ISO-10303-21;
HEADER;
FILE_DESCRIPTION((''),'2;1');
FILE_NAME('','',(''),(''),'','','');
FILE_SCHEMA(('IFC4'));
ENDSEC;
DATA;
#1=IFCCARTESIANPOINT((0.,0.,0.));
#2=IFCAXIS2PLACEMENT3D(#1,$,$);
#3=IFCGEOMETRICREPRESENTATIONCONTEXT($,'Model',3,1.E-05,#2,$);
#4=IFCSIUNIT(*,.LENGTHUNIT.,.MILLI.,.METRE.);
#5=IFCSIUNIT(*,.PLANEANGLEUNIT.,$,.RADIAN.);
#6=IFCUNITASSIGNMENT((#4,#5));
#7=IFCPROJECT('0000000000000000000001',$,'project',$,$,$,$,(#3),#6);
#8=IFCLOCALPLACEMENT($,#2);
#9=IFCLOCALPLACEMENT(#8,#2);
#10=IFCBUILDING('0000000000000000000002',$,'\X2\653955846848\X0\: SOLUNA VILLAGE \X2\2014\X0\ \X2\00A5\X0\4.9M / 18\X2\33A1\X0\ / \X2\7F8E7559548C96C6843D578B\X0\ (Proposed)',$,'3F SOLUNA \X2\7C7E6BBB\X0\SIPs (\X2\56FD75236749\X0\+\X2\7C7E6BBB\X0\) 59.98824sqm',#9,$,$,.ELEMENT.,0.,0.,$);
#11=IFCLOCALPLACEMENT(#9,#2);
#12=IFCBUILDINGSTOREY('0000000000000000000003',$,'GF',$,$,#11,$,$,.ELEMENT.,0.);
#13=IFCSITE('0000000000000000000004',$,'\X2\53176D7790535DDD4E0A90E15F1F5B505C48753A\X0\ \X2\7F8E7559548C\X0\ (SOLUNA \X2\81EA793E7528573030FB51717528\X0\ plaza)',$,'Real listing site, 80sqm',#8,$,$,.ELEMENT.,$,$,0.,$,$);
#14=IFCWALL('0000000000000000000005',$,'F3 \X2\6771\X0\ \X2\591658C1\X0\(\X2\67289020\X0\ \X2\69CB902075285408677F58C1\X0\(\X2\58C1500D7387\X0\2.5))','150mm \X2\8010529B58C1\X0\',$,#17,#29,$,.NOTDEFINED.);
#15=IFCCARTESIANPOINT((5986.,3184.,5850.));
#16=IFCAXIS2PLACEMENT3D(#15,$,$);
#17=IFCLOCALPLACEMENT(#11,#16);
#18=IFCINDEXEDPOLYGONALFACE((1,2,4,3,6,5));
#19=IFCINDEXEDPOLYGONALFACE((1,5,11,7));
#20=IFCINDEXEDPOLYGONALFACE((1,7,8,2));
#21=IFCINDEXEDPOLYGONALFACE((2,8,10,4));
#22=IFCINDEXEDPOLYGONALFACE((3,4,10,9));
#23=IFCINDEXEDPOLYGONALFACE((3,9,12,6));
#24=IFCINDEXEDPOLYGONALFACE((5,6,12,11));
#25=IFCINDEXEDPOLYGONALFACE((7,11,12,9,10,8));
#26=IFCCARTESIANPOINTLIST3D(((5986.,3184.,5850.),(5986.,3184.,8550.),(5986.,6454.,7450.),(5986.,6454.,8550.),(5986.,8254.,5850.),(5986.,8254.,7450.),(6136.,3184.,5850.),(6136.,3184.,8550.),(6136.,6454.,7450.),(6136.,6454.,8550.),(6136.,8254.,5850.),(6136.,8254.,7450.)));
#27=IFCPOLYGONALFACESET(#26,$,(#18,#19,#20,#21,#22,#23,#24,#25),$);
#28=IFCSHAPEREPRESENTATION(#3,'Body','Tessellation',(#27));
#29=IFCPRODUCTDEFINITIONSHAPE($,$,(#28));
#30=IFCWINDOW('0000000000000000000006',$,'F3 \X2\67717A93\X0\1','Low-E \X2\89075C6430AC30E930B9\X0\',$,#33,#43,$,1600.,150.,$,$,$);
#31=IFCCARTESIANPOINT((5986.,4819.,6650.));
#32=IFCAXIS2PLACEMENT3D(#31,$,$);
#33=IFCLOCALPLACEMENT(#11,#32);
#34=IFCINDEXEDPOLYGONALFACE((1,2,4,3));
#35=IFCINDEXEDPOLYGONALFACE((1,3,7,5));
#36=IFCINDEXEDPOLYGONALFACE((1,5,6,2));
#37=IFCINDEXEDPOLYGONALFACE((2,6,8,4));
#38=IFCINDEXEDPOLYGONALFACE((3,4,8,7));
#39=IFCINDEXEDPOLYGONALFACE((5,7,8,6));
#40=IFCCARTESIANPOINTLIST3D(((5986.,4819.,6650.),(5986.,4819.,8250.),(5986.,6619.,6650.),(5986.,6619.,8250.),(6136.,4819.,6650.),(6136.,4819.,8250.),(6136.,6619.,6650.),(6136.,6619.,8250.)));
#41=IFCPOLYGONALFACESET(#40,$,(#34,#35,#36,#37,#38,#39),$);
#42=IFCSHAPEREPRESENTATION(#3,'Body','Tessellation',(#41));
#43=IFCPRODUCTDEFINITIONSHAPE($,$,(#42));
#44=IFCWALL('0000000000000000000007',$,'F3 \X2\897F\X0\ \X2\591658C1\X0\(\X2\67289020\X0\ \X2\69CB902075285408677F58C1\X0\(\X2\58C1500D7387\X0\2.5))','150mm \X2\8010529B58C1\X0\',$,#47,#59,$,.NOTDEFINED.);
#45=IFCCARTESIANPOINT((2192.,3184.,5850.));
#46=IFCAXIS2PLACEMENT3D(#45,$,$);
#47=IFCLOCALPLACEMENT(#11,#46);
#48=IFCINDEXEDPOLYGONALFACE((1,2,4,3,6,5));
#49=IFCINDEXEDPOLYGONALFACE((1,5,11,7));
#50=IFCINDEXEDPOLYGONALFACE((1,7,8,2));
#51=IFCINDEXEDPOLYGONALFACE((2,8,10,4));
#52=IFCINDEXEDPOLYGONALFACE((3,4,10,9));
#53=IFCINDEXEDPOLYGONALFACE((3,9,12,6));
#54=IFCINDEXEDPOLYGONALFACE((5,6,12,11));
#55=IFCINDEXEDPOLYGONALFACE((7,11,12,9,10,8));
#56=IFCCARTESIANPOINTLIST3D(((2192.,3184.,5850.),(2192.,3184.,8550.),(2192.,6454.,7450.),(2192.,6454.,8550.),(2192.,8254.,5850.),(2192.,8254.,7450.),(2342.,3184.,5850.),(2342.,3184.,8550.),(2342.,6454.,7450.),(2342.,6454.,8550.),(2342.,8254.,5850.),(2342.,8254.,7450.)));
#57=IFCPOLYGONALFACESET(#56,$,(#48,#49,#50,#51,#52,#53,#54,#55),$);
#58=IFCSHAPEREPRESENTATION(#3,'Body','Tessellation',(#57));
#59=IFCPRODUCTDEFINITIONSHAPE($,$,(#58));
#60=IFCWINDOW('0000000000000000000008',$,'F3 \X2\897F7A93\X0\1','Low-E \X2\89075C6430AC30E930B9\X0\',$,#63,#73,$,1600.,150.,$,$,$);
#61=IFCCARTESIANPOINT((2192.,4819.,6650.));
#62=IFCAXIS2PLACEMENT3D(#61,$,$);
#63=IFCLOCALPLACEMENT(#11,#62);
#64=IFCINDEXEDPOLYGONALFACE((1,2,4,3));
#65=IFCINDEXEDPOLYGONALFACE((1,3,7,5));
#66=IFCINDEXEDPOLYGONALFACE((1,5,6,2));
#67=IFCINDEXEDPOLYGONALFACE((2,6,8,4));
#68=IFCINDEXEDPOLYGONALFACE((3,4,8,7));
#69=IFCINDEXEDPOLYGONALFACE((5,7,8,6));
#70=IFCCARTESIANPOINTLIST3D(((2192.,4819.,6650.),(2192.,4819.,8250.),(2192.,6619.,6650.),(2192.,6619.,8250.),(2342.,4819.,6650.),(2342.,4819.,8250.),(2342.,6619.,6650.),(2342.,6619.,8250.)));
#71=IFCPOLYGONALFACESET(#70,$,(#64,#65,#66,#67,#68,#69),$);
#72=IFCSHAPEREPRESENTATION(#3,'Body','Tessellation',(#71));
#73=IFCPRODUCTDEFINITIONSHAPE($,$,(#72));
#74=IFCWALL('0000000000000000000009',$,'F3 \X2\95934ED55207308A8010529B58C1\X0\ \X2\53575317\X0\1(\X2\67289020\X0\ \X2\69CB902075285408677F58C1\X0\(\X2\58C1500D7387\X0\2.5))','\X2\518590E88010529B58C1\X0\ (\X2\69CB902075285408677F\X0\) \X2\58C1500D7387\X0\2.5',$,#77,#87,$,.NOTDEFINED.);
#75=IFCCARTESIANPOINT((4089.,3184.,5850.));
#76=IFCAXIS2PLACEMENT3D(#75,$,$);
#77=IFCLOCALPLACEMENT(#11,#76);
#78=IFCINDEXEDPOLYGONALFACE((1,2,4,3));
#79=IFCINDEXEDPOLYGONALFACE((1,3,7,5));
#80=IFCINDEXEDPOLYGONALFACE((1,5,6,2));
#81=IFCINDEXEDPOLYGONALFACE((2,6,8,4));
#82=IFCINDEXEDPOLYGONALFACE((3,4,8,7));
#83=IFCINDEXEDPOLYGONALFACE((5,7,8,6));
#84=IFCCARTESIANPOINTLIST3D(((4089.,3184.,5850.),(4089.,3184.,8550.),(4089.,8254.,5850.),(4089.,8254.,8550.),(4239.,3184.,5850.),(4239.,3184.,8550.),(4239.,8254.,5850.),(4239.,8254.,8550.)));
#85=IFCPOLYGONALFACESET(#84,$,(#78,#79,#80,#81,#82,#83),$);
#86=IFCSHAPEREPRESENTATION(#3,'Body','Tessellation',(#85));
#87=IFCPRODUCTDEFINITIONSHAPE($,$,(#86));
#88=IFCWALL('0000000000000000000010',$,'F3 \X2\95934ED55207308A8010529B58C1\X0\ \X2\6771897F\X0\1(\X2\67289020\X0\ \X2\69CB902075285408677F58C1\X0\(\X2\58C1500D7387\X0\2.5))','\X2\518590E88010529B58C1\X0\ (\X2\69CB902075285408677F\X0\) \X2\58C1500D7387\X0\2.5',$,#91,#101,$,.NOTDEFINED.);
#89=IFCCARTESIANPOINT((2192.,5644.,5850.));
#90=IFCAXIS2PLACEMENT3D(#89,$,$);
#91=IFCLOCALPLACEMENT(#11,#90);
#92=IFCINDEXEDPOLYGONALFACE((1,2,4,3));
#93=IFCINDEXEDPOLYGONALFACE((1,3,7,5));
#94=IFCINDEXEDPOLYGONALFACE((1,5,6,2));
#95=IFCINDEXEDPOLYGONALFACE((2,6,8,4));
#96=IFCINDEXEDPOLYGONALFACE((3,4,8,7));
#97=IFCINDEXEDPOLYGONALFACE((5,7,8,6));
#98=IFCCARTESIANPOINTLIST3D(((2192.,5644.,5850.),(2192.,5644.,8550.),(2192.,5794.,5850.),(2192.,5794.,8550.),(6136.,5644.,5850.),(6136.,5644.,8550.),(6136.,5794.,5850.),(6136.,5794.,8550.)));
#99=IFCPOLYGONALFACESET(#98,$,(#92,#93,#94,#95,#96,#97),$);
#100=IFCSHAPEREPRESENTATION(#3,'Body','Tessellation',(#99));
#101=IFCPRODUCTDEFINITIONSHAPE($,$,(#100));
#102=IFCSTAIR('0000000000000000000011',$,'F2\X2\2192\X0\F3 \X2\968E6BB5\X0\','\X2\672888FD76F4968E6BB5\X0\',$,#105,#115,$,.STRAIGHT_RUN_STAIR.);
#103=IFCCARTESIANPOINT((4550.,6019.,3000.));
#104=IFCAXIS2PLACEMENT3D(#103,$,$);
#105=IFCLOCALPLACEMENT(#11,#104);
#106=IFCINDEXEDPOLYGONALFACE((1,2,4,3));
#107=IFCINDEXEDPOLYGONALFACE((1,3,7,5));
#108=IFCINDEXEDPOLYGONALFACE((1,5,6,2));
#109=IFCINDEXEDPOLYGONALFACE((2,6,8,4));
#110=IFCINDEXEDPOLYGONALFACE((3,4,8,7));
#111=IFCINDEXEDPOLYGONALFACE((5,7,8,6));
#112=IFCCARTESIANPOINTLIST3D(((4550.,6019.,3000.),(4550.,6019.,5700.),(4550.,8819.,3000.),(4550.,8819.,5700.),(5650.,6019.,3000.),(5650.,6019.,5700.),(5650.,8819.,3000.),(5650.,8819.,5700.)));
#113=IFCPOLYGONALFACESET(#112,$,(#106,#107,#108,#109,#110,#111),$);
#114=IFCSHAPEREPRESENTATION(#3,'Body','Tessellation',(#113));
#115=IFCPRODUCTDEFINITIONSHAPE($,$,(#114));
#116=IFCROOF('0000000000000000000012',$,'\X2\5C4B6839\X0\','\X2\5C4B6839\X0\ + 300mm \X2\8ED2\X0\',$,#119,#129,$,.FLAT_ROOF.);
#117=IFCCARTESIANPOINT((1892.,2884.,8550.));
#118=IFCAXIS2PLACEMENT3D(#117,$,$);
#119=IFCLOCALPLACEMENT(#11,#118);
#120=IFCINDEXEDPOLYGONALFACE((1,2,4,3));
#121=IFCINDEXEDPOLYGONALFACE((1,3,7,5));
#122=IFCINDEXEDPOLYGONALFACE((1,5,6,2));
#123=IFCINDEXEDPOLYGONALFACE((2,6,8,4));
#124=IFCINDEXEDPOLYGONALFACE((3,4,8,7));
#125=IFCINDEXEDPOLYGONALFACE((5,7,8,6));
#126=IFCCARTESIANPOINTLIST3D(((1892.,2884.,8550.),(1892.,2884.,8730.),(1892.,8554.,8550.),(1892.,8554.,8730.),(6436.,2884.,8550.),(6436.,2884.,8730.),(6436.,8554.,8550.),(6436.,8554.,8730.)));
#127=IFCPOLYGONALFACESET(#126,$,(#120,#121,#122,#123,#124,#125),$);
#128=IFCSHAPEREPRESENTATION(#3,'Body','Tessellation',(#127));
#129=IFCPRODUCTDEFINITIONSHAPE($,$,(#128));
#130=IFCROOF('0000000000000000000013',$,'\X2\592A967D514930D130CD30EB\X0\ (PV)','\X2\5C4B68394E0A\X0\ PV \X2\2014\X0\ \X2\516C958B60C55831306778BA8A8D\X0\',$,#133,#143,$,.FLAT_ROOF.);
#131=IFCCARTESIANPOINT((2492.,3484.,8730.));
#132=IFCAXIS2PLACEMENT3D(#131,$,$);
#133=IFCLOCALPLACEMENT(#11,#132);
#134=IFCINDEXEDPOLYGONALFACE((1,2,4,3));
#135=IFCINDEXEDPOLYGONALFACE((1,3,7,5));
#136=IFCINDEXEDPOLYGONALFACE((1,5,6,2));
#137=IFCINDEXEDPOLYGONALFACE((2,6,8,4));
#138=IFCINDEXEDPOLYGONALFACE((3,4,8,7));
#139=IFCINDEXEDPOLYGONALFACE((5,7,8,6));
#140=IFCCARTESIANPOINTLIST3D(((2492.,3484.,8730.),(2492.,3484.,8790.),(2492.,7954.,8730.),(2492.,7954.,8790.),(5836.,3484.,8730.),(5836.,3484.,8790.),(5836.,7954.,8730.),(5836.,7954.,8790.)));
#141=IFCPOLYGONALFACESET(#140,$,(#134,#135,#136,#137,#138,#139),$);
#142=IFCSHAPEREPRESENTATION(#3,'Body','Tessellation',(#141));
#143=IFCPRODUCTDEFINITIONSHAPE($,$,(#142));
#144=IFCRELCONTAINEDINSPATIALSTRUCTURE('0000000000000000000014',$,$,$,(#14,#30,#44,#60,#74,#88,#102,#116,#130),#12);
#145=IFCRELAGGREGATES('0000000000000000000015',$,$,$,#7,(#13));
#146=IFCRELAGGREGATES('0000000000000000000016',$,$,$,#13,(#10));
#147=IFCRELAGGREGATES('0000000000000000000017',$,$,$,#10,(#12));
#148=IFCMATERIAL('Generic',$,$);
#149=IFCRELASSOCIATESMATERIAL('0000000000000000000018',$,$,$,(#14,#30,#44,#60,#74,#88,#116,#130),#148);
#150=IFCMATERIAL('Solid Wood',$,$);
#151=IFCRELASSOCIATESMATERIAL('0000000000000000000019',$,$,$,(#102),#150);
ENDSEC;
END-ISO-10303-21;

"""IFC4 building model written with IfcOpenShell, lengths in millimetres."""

from ifc_helpers import new_model, si_unit, frame, frame_2d, origin, place, context, project, spatial, rectangle, extrude, material, element, fill, save


model = new_model("IFC4")

# Units and contexts
model_context = context("Model", 3, precision=1e-05, world=origin())
ifc_project = project(units=[si_unit("LENGTHUNIT", "METRE", prefix="MILLI"), si_unit("PLANEANGLEUNIT", "RADIAN")], contexts=[model_context])

# Site, building, storey
site_placement = place(None, origin())
site = spatial("IfcSite", under=ifc_project, at=site_placement, Name="北海道川上郡弟子屈町 美留和 (SOLUNA 自社用地・共用 plaza)", ObjectType="Real listing site, 80sqm", CompositionType="ELEMENT", RefElevation=0.0)
building_placement = place(site_placement, origin())
building = spatial("IfcBuilding", under=site, at=building_placement, Name="改善案: SOLUNA VILLAGE — ¥4.9M / 18㎡ / 美留和集落型 (Proposed)", ObjectType="3F SOLUNA 籾殻SIPs (国産杉+籾殻) 59.98824sqm", CompositionType="ELEMENT", ElevationOfRefHeight=0.0, ElevationOfTerrain=0.0)
storey_placement = place(building_placement, origin())
storey = spatial("IfcBuildingStorey", under=building, at=storey_placement, Name="GF", CompositionType="ELEMENT", Elevation=0.0)

# Shared definitions
ifc_material_1 = material(Name="Generic")

# Walls, openings, windows
wall_1_placement = place(storey_placement, frame((5986.0, 3184.0, 5850.0)))
wall_1 = element("IfcWall", 1, at=wall_1_placement, inside=storey, material=ifc_material_1, Name="F3 東 外壁(木造 構造用合板壁(壁倍率2.5))", Description="150mm 耐力壁", PredefinedType="NOTDEFINED", context=model_context, shape_type="SweptSolid", body=[
    extrude(rectangle(XDim=150.0, YDim=5070.0, at=frame_2d((75.0, 2535.0))), frame((5986.0, 3184.0, 5850.0)), (0.0, 0.0, 1.0), 2700.0),
])
opening_1_placement = place(storey_placement, frame((5986.0, 4819.0, 6650.0)))
opening_1 = element("IfcOpeningElement", 2, at=opening_1_placement, cuts=wall_1, PredefinedType="NOTDEFINED", context=model_context, shape_type="SweptSolid", body=[
    extrude(rectangle(XDim=150.0, YDim=1800.0, at=frame_2d((75.0, 900.0))), frame((5986.0, 4819.0, 6650.0)), (0.0, 0.0, 1.0), 1600.0),
])
window_1_placement = place(storey_placement, frame((5986.0, 4819.0, 6650.0)))
window_1 = element("IfcWindow", 3, at=window_1_placement, inside=storey, material=ifc_material_1, Name="F3 東窓1", Description="Low-E 複層ガラス", OverallHeight=1600.0, OverallWidth=150.0, context=model_context, shape_type="SweptSolid", body=[
    extrude(rectangle(XDim=150.0, YDim=1800.0, at=frame_2d((75.0, 900.0))), frame((5986.0, 4819.0, 6650.0)), (0.0, 0.0, 1.0), 1600.0),
])
fill(opening_1, window_1)
wall_2_placement = place(storey_placement, frame((2192.0, 3184.0, 5850.0)))
wall_2 = element("IfcWall", 4, at=wall_2_placement, inside=storey, material=ifc_material_1, Name="F3 西 外壁(木造 構造用合板壁(壁倍率2.5))", Description="150mm 耐力壁", PredefinedType="NOTDEFINED", context=model_context, shape_type="SweptSolid", body=[
    extrude(rectangle(XDim=150.0, YDim=5070.0, at=frame_2d((75.0, 2535.0))), frame((2192.0, 3184.0, 5850.0)), (0.0, 0.0, 1.0), 2700.0),
])
opening_2_placement = place(storey_placement, frame((2192.0, 4819.0, 6650.0)))
opening_2 = element("IfcOpeningElement", 5, at=opening_2_placement, cuts=wall_2, PredefinedType="NOTDEFINED", context=model_context, shape_type="SweptSolid", body=[
    extrude(rectangle(XDim=150.0, YDim=1800.0, at=frame_2d((75.0, 900.0))), frame((2192.0, 4819.0, 6650.0)), (0.0, 0.0, 1.0), 1600.0),
])
window_2_placement = place(storey_placement, frame((2192.0, 4819.0, 6650.0)))
window_2 = element("IfcWindow", 6, at=window_2_placement, inside=storey, material=ifc_material_1, Name="F3 西窓1", Description="Low-E 複層ガラス", OverallHeight=1600.0, OverallWidth=150.0, context=model_context, shape_type="SweptSolid", body=[
    extrude(rectangle(XDim=150.0, YDim=1800.0, at=frame_2d((75.0, 900.0))), frame((2192.0, 4819.0, 6650.0)), (0.0, 0.0, 1.0), 1600.0),
])
fill(opening_2, window_2)

# Walls
wall_3_placement = place(storey_placement, frame((4089.0, 3184.0, 5850.0)))
element("IfcWall", 7, at=wall_3_placement, inside=storey, material=ifc_material_1, Name="F3 間仕切り耐力壁 南北1(木造 構造用合板壁(壁倍率2.5))", Description="内部耐力壁 (構造用合板) 壁倍率2.5", PredefinedType="NOTDEFINED", context=model_context, shape_type="SweptSolid", body=[
    extrude(rectangle(XDim=150.0, YDim=5070.0, at=frame_2d((75.0, 2535.0))), frame((4089.0, 3184.0, 5850.0)), (0.0, 0.0, 1.0), 2700.0),
])
wall_4_placement = place(storey_placement, frame((2192.0, 5644.0, 5850.0)))
element("IfcWall", 8, at=wall_4_placement, inside=storey, material=ifc_material_1, Name="F3 間仕切り耐力壁 東西1(木造 構造用合板壁(壁倍率2.5))", Description="内部耐力壁 (構造用合板) 壁倍率2.5", PredefinedType="NOTDEFINED", context=model_context, shape_type="SweptSolid", body=[
    extrude(rectangle(XDim=3944.0, YDim=150.0, at=frame_2d((1972.0, 75.0))), frame((2192.0, 5644.0, 5850.0)), (0.0, 0.0, 1.0), 2700.0),
])

# Stair
ifc_material_2 = material(Name="Solid Wood")
stair_placement = place(storey_placement, frame((4550.0, 6019.0, 3000.0)))
element("IfcStair", 9, at=stair_placement, inside=storey, material=ifc_material_2, Name="F2→F3 階段", Description="木製直階段", PredefinedType="STRAIGHT_RUN_STAIR", context=model_context, shape_type="SweptSolid", body=[
    extrude(rectangle(XDim=1100.0, YDim=2800.0, at=frame_2d((550.0, 1400.0))), frame((4550.0, 6019.0, 3000.0)), (0.0, 0.0, 1.0), 2700.0),
])

# Roofs
roof_1_placement = place(storey_placement, frame((1892.0, 2884.0, 8550.0)))
element("IfcRoof", 10, at=roof_1_placement, inside=storey, material=ifc_material_1, Name="屋根", Description="屋根 + 300mm 軒", PredefinedType="FLAT_ROOF", context=model_context, shape_type="SweptSolid", body=[
    extrude(rectangle(XDim=4544.0, YDim=5670.0, at=frame_2d((2272.0, 2835.0))), frame((1892.0, 2884.0, 8550.0)), (0.0, 0.0, 1.0), 180.0),
])
roof_2_placement = place(storey_placement, frame((2492.0, 3484.0, 8730.0)))
element("IfcRoof", 11, at=roof_2_placement, inside=storey, material=ifc_material_1, Name="太陽光パネル (PV)", Description="屋根上 PV — 公開情報で確認", PredefinedType="FLAT_ROOF", context=model_context, shape_type="SweptSolid", body=[
    extrude(rectangle(XDim=3344.0, YDim=4470.0, at=frame_2d((1672.0, 2235.0))), frame((2492.0, 3484.0, 8730.0)), (0.0, 0.0, 1.0), 60.0),
])

save(model, "model.ifc")
